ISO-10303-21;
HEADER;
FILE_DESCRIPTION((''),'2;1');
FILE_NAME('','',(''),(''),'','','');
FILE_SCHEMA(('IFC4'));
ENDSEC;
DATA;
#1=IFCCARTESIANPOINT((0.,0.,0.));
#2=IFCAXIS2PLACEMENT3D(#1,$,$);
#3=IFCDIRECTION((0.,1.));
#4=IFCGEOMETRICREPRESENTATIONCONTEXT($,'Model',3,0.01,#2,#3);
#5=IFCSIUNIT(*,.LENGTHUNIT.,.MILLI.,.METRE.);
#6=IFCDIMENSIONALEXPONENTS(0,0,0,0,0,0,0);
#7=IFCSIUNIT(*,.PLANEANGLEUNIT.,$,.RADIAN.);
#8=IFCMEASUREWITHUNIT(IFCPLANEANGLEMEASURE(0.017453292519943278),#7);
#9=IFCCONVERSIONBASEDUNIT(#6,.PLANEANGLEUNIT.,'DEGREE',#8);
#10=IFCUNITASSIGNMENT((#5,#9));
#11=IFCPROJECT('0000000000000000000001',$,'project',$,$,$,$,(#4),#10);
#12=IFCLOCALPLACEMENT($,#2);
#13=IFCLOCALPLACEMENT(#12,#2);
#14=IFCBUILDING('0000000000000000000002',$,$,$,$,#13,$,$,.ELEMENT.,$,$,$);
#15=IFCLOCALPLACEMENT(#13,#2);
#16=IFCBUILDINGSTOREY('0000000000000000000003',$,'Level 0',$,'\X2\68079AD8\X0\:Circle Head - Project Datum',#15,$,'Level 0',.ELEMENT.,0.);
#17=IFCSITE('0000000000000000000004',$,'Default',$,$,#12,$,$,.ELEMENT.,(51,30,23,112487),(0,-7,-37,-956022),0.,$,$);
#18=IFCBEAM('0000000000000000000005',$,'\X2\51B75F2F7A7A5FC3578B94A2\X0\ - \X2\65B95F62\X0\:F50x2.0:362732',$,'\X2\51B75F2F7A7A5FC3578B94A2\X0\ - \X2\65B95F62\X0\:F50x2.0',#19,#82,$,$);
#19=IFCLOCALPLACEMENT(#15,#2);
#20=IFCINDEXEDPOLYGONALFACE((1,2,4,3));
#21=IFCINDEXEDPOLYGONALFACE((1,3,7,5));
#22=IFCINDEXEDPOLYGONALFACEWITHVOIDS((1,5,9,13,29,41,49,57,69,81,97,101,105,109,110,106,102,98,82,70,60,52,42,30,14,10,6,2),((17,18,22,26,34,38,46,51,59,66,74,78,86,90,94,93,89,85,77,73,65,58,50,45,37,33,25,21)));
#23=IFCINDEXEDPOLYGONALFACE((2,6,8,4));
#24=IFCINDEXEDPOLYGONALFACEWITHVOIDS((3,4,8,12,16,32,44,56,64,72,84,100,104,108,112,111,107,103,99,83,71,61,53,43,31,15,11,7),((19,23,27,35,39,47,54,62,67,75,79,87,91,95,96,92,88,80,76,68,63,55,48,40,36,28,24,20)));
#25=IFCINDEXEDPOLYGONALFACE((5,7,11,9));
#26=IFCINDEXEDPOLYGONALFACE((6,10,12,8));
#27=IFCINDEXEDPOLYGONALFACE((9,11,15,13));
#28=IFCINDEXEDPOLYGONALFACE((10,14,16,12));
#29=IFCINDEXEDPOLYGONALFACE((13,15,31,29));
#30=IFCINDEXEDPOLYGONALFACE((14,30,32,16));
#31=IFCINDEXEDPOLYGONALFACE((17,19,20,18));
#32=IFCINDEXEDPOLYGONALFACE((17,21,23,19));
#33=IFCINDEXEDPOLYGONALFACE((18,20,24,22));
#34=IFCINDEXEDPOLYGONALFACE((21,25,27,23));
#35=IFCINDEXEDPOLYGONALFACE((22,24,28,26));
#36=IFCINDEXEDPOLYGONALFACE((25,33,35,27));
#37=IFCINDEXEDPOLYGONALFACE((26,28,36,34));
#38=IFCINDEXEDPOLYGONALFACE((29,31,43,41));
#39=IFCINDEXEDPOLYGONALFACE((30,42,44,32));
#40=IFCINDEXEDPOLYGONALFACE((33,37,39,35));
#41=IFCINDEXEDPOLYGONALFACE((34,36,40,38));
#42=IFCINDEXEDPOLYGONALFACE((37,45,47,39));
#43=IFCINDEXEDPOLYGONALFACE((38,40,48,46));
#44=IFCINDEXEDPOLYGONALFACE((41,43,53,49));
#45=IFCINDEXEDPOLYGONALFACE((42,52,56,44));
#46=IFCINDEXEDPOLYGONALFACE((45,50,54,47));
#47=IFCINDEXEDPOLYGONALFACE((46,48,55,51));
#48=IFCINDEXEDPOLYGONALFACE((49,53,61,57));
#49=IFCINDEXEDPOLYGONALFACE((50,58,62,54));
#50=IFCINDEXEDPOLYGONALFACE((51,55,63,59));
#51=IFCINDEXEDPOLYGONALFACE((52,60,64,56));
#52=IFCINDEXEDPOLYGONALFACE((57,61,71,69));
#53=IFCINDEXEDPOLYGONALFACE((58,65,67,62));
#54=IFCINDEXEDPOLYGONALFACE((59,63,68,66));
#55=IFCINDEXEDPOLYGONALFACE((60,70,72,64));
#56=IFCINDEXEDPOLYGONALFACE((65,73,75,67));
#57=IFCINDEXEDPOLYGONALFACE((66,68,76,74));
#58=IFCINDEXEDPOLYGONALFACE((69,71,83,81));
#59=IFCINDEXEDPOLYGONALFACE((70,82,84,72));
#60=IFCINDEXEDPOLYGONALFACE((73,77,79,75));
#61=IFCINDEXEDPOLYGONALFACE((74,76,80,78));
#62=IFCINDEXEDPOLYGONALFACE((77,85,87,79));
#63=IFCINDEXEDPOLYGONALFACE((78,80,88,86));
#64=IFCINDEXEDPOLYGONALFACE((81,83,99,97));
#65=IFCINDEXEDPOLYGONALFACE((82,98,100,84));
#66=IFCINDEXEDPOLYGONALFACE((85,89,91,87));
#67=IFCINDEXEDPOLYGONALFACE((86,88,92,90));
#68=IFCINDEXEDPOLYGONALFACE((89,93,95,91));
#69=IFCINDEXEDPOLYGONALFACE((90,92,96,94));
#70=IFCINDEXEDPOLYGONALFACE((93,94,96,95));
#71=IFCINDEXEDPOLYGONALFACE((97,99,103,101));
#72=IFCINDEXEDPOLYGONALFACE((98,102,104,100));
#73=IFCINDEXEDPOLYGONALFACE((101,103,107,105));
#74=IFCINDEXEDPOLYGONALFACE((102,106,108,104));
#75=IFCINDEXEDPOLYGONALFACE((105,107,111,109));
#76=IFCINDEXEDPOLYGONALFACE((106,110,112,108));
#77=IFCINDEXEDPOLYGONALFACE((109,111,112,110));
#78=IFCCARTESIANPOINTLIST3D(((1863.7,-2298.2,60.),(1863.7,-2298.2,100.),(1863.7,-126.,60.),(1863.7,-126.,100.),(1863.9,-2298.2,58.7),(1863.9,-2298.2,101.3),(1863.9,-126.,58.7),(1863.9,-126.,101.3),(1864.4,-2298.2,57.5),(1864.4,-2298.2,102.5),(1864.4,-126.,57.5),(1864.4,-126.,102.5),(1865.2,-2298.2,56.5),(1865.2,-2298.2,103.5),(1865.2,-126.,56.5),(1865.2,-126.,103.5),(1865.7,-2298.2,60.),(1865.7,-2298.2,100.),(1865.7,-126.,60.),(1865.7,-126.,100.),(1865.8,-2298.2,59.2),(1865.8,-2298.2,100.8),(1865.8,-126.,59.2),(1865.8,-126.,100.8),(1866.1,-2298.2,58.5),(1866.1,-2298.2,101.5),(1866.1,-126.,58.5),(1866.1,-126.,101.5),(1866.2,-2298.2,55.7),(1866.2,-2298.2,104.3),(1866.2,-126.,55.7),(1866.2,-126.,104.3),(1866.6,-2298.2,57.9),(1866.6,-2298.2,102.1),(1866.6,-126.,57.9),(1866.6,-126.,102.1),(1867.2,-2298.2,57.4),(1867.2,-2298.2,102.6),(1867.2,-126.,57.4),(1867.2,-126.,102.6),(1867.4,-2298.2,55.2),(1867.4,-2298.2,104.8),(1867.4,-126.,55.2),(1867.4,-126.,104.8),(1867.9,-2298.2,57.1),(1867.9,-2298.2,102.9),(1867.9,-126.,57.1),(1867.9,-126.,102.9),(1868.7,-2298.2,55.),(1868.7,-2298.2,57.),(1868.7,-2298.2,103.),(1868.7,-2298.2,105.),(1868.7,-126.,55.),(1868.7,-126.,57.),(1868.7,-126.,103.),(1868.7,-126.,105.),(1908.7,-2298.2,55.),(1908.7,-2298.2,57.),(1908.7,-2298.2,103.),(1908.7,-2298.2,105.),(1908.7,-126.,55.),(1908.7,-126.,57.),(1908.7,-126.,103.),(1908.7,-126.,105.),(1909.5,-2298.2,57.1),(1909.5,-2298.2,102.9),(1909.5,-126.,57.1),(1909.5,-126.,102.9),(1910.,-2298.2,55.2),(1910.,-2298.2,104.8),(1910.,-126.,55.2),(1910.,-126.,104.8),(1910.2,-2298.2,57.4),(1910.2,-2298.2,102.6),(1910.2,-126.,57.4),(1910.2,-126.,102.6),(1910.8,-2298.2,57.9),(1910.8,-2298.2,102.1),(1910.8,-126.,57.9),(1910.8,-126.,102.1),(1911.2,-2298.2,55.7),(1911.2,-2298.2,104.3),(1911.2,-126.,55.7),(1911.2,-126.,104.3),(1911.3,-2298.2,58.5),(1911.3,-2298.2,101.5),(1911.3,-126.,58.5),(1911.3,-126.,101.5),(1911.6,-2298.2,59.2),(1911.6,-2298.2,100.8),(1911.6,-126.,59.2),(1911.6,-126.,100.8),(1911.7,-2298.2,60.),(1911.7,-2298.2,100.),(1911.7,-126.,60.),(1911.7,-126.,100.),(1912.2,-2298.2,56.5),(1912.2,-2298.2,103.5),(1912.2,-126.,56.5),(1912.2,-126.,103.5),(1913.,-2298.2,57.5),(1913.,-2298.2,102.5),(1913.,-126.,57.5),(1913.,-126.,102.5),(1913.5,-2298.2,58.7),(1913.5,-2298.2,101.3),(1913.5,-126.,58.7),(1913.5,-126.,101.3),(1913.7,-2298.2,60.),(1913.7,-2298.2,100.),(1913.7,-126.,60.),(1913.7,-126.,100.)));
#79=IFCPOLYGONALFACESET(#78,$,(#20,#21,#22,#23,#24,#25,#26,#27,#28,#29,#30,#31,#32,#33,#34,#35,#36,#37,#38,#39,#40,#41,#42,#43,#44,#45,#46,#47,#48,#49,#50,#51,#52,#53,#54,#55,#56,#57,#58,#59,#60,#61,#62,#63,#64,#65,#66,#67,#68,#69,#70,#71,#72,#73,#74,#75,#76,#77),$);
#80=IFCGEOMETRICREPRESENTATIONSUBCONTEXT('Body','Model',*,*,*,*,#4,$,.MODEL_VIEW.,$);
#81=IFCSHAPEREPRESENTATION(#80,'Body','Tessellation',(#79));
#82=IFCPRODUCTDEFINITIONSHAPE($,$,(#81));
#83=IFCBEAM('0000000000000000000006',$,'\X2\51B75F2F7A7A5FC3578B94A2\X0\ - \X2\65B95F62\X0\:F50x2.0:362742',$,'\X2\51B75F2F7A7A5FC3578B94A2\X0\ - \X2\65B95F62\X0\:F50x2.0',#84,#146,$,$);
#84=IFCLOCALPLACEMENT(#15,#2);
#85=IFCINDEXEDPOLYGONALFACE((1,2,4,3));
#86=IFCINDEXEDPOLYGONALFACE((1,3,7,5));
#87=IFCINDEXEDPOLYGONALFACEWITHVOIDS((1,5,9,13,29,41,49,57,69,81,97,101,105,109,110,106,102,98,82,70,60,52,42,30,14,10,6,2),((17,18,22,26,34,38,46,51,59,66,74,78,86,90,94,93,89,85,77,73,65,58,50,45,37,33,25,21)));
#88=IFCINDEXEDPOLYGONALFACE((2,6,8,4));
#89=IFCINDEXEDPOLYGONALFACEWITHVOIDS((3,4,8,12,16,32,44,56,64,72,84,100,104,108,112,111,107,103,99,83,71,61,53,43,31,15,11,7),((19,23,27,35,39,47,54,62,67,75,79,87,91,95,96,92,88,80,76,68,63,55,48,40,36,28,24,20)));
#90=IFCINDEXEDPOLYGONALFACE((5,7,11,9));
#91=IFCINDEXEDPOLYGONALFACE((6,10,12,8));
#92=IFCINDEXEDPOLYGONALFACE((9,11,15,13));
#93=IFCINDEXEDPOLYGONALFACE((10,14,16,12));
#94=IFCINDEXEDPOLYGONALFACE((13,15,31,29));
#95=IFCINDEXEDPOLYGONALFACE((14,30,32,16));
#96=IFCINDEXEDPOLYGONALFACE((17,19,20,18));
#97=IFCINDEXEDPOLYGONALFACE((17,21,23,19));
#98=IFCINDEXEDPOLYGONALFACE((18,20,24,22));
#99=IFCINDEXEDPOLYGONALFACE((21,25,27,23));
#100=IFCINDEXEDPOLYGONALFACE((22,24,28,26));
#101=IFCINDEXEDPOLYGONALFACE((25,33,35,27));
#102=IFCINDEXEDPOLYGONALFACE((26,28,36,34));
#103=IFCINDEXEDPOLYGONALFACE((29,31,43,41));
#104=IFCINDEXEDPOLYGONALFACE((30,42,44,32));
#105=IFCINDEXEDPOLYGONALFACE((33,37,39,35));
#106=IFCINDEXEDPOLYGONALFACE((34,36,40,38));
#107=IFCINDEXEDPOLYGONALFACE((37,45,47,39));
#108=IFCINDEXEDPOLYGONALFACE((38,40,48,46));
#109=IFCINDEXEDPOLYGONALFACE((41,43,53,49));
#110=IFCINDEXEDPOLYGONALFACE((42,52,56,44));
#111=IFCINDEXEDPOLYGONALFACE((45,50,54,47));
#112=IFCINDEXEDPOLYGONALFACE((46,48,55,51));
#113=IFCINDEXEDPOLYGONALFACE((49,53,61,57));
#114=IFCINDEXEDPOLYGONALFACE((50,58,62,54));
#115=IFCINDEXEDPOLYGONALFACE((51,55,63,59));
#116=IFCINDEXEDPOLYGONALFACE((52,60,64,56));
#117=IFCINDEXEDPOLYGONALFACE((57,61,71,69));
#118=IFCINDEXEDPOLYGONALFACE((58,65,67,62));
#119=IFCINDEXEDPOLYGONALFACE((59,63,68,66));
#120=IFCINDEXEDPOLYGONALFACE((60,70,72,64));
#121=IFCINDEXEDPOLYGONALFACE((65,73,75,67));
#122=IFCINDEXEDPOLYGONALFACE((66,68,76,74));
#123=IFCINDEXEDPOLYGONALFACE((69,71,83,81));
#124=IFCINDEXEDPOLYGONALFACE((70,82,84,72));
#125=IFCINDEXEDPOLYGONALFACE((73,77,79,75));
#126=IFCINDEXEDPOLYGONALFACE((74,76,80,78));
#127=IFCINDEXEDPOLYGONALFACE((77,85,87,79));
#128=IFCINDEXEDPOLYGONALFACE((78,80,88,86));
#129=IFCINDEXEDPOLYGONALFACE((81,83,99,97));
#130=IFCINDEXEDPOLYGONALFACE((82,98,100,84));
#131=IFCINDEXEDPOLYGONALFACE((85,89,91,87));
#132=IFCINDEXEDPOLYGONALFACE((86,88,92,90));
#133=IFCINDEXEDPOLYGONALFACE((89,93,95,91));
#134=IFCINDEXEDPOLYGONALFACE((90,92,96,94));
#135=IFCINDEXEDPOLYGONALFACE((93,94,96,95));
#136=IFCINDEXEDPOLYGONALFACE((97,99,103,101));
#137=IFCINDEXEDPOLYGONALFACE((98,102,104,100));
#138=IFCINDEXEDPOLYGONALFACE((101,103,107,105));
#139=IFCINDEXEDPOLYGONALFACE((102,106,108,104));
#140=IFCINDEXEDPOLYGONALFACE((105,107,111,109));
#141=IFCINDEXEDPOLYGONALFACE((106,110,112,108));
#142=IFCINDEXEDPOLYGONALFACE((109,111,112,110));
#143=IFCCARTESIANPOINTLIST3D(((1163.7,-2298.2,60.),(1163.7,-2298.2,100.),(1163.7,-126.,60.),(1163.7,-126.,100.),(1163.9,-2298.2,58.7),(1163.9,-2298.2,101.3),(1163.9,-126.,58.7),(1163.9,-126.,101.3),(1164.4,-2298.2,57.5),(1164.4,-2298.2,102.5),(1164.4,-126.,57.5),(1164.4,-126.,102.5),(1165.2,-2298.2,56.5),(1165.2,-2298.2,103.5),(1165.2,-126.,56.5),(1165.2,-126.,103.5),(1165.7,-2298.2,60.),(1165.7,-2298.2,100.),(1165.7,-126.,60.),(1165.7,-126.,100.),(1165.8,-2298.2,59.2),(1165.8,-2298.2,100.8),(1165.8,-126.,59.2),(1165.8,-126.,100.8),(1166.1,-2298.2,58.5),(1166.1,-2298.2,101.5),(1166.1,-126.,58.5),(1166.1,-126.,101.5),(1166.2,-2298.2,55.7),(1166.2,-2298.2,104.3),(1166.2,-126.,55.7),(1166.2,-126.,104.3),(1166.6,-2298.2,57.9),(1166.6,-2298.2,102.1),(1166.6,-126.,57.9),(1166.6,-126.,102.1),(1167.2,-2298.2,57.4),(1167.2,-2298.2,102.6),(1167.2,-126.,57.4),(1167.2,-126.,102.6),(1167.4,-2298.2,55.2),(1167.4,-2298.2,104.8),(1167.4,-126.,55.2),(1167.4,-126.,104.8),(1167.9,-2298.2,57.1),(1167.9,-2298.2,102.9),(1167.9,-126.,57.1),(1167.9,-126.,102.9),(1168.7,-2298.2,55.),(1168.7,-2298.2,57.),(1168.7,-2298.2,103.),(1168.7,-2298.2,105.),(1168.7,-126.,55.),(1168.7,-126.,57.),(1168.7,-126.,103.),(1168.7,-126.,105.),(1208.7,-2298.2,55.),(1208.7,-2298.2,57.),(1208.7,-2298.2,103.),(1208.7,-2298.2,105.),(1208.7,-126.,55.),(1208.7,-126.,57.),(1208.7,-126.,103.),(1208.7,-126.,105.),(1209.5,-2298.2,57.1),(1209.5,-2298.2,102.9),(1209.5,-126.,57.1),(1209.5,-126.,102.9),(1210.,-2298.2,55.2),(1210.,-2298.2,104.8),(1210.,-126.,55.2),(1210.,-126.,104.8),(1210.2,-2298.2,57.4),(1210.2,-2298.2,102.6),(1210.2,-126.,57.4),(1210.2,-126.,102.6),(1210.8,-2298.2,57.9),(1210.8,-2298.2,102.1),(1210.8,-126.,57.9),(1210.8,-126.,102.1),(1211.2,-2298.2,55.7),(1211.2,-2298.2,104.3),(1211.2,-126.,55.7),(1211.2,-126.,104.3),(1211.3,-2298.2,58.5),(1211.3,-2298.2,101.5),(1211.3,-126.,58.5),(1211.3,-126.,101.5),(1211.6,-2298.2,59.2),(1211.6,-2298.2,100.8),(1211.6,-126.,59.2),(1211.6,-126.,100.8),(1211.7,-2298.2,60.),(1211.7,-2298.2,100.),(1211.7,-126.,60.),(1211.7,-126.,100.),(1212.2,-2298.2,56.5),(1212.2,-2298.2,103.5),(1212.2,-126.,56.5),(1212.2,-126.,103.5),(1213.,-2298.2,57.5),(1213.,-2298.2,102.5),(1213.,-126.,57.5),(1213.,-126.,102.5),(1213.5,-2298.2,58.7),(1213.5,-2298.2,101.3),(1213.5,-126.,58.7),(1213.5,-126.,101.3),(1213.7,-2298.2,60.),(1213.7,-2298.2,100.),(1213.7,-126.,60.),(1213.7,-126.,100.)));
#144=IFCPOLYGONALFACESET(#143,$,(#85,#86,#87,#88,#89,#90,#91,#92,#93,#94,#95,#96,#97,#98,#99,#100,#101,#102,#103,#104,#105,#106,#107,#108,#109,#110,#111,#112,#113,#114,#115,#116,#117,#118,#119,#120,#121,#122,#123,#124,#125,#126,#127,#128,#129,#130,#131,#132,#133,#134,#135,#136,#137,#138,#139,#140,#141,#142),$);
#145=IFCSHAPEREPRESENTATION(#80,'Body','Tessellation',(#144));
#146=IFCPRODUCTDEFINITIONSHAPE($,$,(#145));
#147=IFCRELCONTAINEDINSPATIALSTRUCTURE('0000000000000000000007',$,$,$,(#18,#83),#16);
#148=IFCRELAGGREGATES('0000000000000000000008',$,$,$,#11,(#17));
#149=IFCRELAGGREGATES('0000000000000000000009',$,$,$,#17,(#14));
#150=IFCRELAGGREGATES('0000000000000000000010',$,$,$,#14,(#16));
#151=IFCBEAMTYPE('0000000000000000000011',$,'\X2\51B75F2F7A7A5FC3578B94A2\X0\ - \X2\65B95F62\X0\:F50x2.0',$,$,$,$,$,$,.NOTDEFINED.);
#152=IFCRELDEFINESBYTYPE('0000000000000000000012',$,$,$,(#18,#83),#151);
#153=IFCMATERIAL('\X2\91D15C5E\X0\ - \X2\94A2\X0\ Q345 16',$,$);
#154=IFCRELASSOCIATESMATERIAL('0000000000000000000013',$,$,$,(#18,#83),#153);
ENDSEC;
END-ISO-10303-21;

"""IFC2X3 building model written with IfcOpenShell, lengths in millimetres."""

from ifc_helpers import new_model, entity, si_unit, converted_unit, direction, frame, frame_2d, origin, place, context, subcontext, project, spatial, polyline, circle_curve, parameter, trimmed, segment, composite_curve, outline, extrude, material, type_object, element, save


model = new_model("IFC2X3")

# Units and contexts
model_context = context("Model", 3, precision=0.01, world=origin(), true_north=direction((0.0, 1.0)))
body_context = subcontext(model_context, "Body", "Model", "MODEL_VIEW")
ifc_project = project(units=[si_unit("LENGTHUNIT", "METRE", prefix="MILLI"), converted_unit("PLANEANGLEUNIT", "DEGREE", entity("IfcPlaneAngleMeasure", 0.017453292519943278), si_unit("PLANEANGLEUNIT", "RADIAN"), dimensions=[0, 0, 0, 0, 0, 0, 0])], contexts=[model_context])

# Site, building, storey
site_placement = place(None, origin())
site = spatial("IfcSite", under=ifc_project, at=site_placement, Name="Default", CompositionType="ELEMENT", RefLatitude=(51, 30, 23, 112487), RefLongitude=(0, -7, -37, -956022), RefElevation=0.0)
building_placement = place(site_placement, origin())
building = spatial("IfcBuilding", under=site, at=building_placement, CompositionType="ELEMENT")
storey_placement = place(building_placement, origin())
storey = spatial("IfcBuildingStorey", under=building, at=storey_placement, Name="Level 0", ObjectType="标高:Circle Head - Project Datum", LongName="Level 0", CompositionType="ELEMENT", Elevation=0.0)

# Beams
ifc_material_1 = material(Name="金属 - 钢 Q345 16")
beam_type_1 = type_object("IfcBeamType", Name="冷弯空心型钢 - 方形:F50x2.0", PredefinedType="NOTDEFINED")
beam_1_placement = place(storey_placement, frame((1888.7, -390.5, 105.0), z_axis=(0.0, 0.0, 1.0), x_axis=(0.0, -1.0, 0.0)))
element("IfcBeam", 1, at=beam_1_placement, inside=storey, type_object=beam_type_1, material=ifc_material_1, Name="冷弯空心型钢 - 方形:F50x2.0:362732", ObjectType="冷弯空心型钢 - 方形:F50x2.0", context=body_context, shape_type="SweptSolid", body=[
    extrude(outline(composite_curve([segment(trimmed(circle_curve(frame_2d((-20.0, 20.0), x_axis=(1.0, 0.0)), 5.0), [parameter(90.0)], [parameter(180.0)], True, "PARAMETER"), True, "CONTINUOUS"), segment(polyline([(-25.0, 20.0), (-25.0, -20.0)]), True, "CONTINUOUS"), segment(trimmed(circle_curve(frame_2d((-20.0, -20.0), x_axis=(1.0, 0.0)), 5.0), [parameter(180.0)], [parameter(270.0)], True, "PARAMETER"), True, "CONTINUOUS"), segment(polyline([(-20.0, -25.0), (20.0, -25.0)]), True, "CONTINUOUS"), segment(trimmed(circle_curve(frame_2d((20.0, -20.0), x_axis=(1.0, 0.0)), 5.0), [parameter(270.0)], [parameter(0.0)], True, "PARAMETER"), True, "CONTINUOUS"), segment(polyline([(25.0, -20.0), (25.0, 20.0)]), True, "CONTINUOUS"), segment(trimmed(circle_curve(frame_2d((20.0, 20.0), x_axis=(1.0, 0.0)), 5.0), [parameter(0.0)], [parameter(90.0)], True, "PARAMETER"), True, "CONTINUOUS"), segment(polyline([(20.0, 25.0), (-20.0, 25.0)]), True, "CONTINUOUS")], self_intersect=False), holes=[composite_curve([segment(polyline([(-20.0, 23.0), (20.0, 23.0)]), True, "CONTINUOUS"), segment(trimmed(circle_curve(frame_2d((20.0, 20.0), x_axis=(1.0, 0.0)), 3.0), [parameter(360.0)], [parameter(90.0)], True, "PARAMETER"), False, "CONTINUOUS"), segment(polyline([(23.0, 20.0), (23.0, -20.0)]), True, "CONTINUOUS"), segment(trimmed(circle_curve(frame_2d((20.0, -20.0), x_axis=(1.0, 0.0)), 3.0), [parameter(270.0)], [parameter(360.0)], True, "PARAMETER"), False, "CONTINUOUS"), segment(polyline([(20.0, -23.0), (-20.0, -23.0)]), True, "CONTINUOUS"), segment(trimmed(circle_curve(frame_2d((-20.0, -20.0), x_axis=(1.0, 0.0)), 3.0), [parameter(180.0)], [parameter(270.0)], True, "PARAMETER"), False, "CONTINUOUS"), segment(polyline([(-23.0, -20.0), (-23.0, 20.0)]), True, "CONTINUOUS"), segment(trimmed(circle_curve(frame_2d((-20.0, 20.0), x_axis=(1.0, 0.0)), 3.0), [parameter(90.0)], [parameter(180.0)], True, "PARAMETER"), False, "CONTINUOUS")], self_intersect=False)]), frame((-264.5, 0.0, -25.0), z_axis=(1.0, 0.0, 0.0), x_axis=(0.0, 1.0, 0.0)), (0.0, 0.0, 1.0), 2172.2),
])
beam_2_placement = place(storey_placement, frame((1188.7, -390.5, 105.0), z_axis=(0.0, 0.0, 1.0), x_axis=(0.0, -1.0, 0.0)))
element("IfcBeam", 2, at=beam_2_placement, inside=storey, type_object=beam_type_1, material=ifc_material_1, Name="冷弯空心型钢 - 方形:F50x2.0:362742", ObjectType="冷弯空心型钢 - 方形:F50x2.0", context=body_context, shape_type="SweptSolid", body=[
    extrude(outline(composite_curve([segment(trimmed(circle_curve(frame_2d((-20.0, 20.0), x_axis=(1.0, 0.0)), 5.0), [parameter(90.0)], [parameter(180.0)], True, "PARAMETER"), True, "CONTINUOUS"), segment(polyline([(-25.0, 20.0), (-25.0, -20.0)]), True, "CONTINUOUS"), segment(trimmed(circle_curve(frame_2d((-20.0, -20.0), x_axis=(1.0, 0.0)), 5.0), [parameter(180.0)], [parameter(270.0)], True, "PARAMETER"), True, "CONTINUOUS"), segment(polyline([(-20.0, -25.0), (20.0, -25.0)]), True, "CONTINUOUS"), segment(trimmed(circle_curve(frame_2d((20.0, -20.0), x_axis=(1.0, 0.0)), 5.0), [parameter(270.0)], [parameter(0.0)], True, "PARAMETER"), True, "CONTINUOUS"), segment(polyline([(25.0, -20.0), (25.0, 20.0)]), True, "CONTINUOUS"), segment(trimmed(circle_curve(frame_2d((20.0, 20.0), x_axis=(1.0, 0.0)), 5.0), [parameter(0.0)], [parameter(90.0)], True, "PARAMETER"), True, "CONTINUOUS"), segment(polyline([(20.0, 25.0), (-20.0, 25.0)]), True, "CONTINUOUS")], self_intersect=False), holes=[composite_curve([segment(polyline([(-20.0, 23.0), (20.0, 23.0)]), True, "CONTINUOUS"), segment(trimmed(circle_curve(frame_2d((20.0, 20.0), x_axis=(1.0, 0.0)), 3.0), [parameter(360.0)], [parameter(90.0)], True, "PARAMETER"), False, "CONTINUOUS"), segment(polyline([(23.0, 20.0), (23.0, -20.0)]), True, "CONTINUOUS"), segment(trimmed(circle_curve(frame_2d((20.0, -20.0), x_axis=(1.0, 0.0)), 3.0), [parameter(270.0)], [parameter(360.0)], True, "PARAMETER"), False, "CONTINUOUS"), segment(polyline([(20.0, -23.0), (-20.0, -23.0)]), True, "CONTINUOUS"), segment(trimmed(circle_curve(frame_2d((-20.0, -20.0), x_axis=(1.0, 0.0)), 3.0), [parameter(180.0)], [parameter(270.0)], True, "PARAMETER"), False, "CONTINUOUS"), segment(polyline([(-23.0, -20.0), (-23.0, 20.0)]), True, "CONTINUOUS"), segment(trimmed(circle_curve(frame_2d((-20.0, 20.0), x_axis=(1.0, 0.0)), 3.0), [parameter(90.0)], [parameter(180.0)], True, "PARAMETER"), False, "CONTINUOUS")], self_intersect=False)]), frame((-264.5, 0.0, -25.0), z_axis=(1.0, 0.0, 0.0), x_axis=(0.0, 1.0, 0.0)), (0.0, 0.0, 1.0), 2172.2),
])

save(model, "model.ifc")
